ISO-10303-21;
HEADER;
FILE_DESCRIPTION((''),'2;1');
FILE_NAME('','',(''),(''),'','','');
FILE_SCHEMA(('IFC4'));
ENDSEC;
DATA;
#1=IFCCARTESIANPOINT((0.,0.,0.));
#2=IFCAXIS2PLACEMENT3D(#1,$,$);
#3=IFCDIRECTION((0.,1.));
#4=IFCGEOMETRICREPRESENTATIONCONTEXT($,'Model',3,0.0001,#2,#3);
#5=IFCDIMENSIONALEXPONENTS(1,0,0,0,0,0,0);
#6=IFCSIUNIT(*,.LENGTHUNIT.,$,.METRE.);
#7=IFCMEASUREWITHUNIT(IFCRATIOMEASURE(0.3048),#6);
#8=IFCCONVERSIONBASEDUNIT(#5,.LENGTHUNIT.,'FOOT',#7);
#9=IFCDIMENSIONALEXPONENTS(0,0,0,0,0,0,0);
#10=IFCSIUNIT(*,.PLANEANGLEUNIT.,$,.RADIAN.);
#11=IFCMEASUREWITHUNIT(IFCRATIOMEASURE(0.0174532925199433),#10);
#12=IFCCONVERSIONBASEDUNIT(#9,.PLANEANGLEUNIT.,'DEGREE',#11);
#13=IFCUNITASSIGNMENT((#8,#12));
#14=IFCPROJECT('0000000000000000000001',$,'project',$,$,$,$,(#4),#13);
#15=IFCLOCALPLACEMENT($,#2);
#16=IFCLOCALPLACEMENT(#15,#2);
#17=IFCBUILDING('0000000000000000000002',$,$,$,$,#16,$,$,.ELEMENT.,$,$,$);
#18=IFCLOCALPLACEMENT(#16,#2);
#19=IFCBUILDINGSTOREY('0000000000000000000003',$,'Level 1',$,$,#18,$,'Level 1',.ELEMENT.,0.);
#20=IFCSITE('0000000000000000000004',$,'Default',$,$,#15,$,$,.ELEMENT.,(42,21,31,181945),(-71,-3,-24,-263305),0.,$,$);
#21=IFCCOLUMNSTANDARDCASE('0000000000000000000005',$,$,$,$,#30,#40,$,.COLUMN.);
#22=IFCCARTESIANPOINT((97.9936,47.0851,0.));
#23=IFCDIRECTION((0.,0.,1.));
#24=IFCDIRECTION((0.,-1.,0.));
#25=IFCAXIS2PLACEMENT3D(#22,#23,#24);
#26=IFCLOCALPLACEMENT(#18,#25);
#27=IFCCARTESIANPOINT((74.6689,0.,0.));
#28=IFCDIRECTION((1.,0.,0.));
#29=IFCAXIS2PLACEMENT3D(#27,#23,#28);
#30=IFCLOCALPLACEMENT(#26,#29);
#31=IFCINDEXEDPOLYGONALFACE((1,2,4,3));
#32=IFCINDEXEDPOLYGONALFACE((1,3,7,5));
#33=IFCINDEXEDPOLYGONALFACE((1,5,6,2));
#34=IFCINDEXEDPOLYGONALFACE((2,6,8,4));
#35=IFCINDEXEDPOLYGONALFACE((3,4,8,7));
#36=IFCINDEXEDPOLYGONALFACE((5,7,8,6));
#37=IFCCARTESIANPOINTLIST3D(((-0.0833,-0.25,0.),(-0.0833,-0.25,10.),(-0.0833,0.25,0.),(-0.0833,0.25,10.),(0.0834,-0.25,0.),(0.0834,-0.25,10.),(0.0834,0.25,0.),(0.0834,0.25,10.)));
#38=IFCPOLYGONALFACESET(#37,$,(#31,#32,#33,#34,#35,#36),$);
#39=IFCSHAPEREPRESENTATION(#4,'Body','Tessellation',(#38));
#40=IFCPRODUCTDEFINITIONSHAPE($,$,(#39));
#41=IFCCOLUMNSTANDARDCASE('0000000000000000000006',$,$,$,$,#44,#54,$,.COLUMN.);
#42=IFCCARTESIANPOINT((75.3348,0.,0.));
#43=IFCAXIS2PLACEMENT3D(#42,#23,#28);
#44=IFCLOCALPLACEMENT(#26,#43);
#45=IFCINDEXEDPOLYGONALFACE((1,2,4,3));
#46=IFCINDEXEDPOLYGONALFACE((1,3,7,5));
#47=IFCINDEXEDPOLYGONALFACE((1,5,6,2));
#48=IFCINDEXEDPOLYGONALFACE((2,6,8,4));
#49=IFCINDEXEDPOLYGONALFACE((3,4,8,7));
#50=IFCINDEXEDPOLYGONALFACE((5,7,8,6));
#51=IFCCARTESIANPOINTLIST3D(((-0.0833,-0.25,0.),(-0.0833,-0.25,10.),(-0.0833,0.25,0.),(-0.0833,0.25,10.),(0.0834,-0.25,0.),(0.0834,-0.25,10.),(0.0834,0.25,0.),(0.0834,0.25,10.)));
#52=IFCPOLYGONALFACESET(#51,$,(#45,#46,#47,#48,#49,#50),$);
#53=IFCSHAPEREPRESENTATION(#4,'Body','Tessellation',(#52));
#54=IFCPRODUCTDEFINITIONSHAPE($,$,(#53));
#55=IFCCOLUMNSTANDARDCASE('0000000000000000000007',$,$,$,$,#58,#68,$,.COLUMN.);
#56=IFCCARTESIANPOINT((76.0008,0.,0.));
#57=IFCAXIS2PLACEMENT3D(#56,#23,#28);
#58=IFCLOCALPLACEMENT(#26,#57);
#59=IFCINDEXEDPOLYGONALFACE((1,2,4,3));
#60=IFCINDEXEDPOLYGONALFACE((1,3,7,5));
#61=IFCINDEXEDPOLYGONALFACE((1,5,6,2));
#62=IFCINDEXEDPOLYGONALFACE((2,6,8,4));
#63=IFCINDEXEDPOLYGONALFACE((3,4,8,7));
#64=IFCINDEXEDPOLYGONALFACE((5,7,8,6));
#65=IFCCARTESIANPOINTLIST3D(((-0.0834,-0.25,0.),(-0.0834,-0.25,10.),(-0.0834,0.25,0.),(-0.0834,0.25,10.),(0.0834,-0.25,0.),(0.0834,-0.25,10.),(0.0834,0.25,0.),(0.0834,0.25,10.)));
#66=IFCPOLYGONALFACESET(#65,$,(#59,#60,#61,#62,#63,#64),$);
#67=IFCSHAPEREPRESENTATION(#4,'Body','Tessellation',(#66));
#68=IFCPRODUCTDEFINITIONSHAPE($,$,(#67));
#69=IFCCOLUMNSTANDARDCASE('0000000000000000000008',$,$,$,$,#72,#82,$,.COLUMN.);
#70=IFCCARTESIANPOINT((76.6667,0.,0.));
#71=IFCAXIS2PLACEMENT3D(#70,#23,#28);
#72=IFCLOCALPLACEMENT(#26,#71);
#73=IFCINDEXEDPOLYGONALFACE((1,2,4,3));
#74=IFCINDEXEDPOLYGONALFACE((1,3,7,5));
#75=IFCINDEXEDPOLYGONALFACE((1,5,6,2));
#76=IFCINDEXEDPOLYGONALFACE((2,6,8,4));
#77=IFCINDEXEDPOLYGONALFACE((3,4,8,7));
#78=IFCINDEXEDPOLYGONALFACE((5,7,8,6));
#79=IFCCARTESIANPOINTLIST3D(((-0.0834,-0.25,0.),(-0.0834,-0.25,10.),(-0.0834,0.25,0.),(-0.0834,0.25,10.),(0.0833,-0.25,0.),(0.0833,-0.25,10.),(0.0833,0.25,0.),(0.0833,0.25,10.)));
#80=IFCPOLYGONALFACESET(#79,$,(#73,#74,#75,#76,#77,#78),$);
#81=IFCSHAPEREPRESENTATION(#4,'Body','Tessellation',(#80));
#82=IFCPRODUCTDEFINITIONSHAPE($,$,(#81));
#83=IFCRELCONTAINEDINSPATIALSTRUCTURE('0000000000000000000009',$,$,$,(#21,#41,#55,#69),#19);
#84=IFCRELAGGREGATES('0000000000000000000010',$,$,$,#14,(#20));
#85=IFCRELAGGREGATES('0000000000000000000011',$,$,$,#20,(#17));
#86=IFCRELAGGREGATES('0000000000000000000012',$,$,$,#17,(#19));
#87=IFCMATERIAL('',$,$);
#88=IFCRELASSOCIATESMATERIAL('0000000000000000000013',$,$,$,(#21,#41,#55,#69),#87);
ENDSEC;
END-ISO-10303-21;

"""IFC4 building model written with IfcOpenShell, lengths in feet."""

from ifc_helpers import new_model, entity, si_unit, converted_unit, direction, frame, origin, place, context, project, spatial, rectangle, extrude, material, element, save


model = new_model("IFC4")

# Units and contexts
model_context = context("Model", 3, precision=0.0001, world=origin(), true_north=direction((0.0, 1.0)))
ifc_project = project(units=[converted_unit("LENGTHUNIT", "FOOT", entity("IfcRatioMeasure", 0.3048), si_unit("LENGTHUNIT", "METRE"), dimensions=[1, 0, 0, 0, 0, 0, 0]), converted_unit("PLANEANGLEUNIT", "DEGREE", entity("IfcRatioMeasure", 0.0174532925199433), si_unit("PLANEANGLEUNIT", "RADIAN"), dimensions=[0, 0, 0, 0, 0, 0, 0])], contexts=[model_context])

# Site, building, storey
site_placement = place(None, origin())
site = spatial("IfcSite", under=ifc_project, at=site_placement, Name="Default", CompositionType="ELEMENT", RefLatitude=(42, 21, 31, 181945), RefLongitude=(-71, -3, -24, -263305), RefElevation=0.0)
building_placement = place(site_placement, origin())
building = spatial("IfcBuilding", under=site, at=building_placement, CompositionType="ELEMENT")
storey_placement = place(building_placement, origin())
storey = spatial("IfcBuildingStorey", under=building, at=storey_placement, Name="Level 1", LongName="Level 1", CompositionType="ELEMENT", Elevation=0.0)

# Columns
ifc_material_1 = material(Name="")
placement = place(storey_placement, frame((97.9936, 47.0851, 0.0), z_axis=(0.0, 0.0, 1.0), x_axis=(0.0, -1.0, 0.0)))
for number, where, z_axis, x_axis in (
    (1, (74.6689, 0.0, 0.0), (0.0, 0.0, 1.0), (1.0, 0.0, 0.0)),
    (2, (75.3348, 0.0, 0.0), (0.0, 0.0, 1.0), (1.0, 0.0, 0.0)),
    (3, (76.0008, 0.0, 0.0), (0.0, 0.0, 1.0), (1.0, 0.0, 0.0)),
    (4, (76.6667, 0.0, 0.0), (0.0, 0.0, 1.0), (1.0, 0.0, 0.0)),
):
    element("IfcColumnStandardCase", number, at=place(placement, frame(where, z_axis=z_axis, x_axis=x_axis)), inside=storey, material=ifc_material_1, PredefinedType="COLUMN", context=model_context, shape_type="SweptSolid", body=[
        extrude(rectangle(XDim=0.1667, YDim=0.5), origin(), (0.0, 0.0, 1.0), 10.0),
    ])

save(model, "model.ifc")
